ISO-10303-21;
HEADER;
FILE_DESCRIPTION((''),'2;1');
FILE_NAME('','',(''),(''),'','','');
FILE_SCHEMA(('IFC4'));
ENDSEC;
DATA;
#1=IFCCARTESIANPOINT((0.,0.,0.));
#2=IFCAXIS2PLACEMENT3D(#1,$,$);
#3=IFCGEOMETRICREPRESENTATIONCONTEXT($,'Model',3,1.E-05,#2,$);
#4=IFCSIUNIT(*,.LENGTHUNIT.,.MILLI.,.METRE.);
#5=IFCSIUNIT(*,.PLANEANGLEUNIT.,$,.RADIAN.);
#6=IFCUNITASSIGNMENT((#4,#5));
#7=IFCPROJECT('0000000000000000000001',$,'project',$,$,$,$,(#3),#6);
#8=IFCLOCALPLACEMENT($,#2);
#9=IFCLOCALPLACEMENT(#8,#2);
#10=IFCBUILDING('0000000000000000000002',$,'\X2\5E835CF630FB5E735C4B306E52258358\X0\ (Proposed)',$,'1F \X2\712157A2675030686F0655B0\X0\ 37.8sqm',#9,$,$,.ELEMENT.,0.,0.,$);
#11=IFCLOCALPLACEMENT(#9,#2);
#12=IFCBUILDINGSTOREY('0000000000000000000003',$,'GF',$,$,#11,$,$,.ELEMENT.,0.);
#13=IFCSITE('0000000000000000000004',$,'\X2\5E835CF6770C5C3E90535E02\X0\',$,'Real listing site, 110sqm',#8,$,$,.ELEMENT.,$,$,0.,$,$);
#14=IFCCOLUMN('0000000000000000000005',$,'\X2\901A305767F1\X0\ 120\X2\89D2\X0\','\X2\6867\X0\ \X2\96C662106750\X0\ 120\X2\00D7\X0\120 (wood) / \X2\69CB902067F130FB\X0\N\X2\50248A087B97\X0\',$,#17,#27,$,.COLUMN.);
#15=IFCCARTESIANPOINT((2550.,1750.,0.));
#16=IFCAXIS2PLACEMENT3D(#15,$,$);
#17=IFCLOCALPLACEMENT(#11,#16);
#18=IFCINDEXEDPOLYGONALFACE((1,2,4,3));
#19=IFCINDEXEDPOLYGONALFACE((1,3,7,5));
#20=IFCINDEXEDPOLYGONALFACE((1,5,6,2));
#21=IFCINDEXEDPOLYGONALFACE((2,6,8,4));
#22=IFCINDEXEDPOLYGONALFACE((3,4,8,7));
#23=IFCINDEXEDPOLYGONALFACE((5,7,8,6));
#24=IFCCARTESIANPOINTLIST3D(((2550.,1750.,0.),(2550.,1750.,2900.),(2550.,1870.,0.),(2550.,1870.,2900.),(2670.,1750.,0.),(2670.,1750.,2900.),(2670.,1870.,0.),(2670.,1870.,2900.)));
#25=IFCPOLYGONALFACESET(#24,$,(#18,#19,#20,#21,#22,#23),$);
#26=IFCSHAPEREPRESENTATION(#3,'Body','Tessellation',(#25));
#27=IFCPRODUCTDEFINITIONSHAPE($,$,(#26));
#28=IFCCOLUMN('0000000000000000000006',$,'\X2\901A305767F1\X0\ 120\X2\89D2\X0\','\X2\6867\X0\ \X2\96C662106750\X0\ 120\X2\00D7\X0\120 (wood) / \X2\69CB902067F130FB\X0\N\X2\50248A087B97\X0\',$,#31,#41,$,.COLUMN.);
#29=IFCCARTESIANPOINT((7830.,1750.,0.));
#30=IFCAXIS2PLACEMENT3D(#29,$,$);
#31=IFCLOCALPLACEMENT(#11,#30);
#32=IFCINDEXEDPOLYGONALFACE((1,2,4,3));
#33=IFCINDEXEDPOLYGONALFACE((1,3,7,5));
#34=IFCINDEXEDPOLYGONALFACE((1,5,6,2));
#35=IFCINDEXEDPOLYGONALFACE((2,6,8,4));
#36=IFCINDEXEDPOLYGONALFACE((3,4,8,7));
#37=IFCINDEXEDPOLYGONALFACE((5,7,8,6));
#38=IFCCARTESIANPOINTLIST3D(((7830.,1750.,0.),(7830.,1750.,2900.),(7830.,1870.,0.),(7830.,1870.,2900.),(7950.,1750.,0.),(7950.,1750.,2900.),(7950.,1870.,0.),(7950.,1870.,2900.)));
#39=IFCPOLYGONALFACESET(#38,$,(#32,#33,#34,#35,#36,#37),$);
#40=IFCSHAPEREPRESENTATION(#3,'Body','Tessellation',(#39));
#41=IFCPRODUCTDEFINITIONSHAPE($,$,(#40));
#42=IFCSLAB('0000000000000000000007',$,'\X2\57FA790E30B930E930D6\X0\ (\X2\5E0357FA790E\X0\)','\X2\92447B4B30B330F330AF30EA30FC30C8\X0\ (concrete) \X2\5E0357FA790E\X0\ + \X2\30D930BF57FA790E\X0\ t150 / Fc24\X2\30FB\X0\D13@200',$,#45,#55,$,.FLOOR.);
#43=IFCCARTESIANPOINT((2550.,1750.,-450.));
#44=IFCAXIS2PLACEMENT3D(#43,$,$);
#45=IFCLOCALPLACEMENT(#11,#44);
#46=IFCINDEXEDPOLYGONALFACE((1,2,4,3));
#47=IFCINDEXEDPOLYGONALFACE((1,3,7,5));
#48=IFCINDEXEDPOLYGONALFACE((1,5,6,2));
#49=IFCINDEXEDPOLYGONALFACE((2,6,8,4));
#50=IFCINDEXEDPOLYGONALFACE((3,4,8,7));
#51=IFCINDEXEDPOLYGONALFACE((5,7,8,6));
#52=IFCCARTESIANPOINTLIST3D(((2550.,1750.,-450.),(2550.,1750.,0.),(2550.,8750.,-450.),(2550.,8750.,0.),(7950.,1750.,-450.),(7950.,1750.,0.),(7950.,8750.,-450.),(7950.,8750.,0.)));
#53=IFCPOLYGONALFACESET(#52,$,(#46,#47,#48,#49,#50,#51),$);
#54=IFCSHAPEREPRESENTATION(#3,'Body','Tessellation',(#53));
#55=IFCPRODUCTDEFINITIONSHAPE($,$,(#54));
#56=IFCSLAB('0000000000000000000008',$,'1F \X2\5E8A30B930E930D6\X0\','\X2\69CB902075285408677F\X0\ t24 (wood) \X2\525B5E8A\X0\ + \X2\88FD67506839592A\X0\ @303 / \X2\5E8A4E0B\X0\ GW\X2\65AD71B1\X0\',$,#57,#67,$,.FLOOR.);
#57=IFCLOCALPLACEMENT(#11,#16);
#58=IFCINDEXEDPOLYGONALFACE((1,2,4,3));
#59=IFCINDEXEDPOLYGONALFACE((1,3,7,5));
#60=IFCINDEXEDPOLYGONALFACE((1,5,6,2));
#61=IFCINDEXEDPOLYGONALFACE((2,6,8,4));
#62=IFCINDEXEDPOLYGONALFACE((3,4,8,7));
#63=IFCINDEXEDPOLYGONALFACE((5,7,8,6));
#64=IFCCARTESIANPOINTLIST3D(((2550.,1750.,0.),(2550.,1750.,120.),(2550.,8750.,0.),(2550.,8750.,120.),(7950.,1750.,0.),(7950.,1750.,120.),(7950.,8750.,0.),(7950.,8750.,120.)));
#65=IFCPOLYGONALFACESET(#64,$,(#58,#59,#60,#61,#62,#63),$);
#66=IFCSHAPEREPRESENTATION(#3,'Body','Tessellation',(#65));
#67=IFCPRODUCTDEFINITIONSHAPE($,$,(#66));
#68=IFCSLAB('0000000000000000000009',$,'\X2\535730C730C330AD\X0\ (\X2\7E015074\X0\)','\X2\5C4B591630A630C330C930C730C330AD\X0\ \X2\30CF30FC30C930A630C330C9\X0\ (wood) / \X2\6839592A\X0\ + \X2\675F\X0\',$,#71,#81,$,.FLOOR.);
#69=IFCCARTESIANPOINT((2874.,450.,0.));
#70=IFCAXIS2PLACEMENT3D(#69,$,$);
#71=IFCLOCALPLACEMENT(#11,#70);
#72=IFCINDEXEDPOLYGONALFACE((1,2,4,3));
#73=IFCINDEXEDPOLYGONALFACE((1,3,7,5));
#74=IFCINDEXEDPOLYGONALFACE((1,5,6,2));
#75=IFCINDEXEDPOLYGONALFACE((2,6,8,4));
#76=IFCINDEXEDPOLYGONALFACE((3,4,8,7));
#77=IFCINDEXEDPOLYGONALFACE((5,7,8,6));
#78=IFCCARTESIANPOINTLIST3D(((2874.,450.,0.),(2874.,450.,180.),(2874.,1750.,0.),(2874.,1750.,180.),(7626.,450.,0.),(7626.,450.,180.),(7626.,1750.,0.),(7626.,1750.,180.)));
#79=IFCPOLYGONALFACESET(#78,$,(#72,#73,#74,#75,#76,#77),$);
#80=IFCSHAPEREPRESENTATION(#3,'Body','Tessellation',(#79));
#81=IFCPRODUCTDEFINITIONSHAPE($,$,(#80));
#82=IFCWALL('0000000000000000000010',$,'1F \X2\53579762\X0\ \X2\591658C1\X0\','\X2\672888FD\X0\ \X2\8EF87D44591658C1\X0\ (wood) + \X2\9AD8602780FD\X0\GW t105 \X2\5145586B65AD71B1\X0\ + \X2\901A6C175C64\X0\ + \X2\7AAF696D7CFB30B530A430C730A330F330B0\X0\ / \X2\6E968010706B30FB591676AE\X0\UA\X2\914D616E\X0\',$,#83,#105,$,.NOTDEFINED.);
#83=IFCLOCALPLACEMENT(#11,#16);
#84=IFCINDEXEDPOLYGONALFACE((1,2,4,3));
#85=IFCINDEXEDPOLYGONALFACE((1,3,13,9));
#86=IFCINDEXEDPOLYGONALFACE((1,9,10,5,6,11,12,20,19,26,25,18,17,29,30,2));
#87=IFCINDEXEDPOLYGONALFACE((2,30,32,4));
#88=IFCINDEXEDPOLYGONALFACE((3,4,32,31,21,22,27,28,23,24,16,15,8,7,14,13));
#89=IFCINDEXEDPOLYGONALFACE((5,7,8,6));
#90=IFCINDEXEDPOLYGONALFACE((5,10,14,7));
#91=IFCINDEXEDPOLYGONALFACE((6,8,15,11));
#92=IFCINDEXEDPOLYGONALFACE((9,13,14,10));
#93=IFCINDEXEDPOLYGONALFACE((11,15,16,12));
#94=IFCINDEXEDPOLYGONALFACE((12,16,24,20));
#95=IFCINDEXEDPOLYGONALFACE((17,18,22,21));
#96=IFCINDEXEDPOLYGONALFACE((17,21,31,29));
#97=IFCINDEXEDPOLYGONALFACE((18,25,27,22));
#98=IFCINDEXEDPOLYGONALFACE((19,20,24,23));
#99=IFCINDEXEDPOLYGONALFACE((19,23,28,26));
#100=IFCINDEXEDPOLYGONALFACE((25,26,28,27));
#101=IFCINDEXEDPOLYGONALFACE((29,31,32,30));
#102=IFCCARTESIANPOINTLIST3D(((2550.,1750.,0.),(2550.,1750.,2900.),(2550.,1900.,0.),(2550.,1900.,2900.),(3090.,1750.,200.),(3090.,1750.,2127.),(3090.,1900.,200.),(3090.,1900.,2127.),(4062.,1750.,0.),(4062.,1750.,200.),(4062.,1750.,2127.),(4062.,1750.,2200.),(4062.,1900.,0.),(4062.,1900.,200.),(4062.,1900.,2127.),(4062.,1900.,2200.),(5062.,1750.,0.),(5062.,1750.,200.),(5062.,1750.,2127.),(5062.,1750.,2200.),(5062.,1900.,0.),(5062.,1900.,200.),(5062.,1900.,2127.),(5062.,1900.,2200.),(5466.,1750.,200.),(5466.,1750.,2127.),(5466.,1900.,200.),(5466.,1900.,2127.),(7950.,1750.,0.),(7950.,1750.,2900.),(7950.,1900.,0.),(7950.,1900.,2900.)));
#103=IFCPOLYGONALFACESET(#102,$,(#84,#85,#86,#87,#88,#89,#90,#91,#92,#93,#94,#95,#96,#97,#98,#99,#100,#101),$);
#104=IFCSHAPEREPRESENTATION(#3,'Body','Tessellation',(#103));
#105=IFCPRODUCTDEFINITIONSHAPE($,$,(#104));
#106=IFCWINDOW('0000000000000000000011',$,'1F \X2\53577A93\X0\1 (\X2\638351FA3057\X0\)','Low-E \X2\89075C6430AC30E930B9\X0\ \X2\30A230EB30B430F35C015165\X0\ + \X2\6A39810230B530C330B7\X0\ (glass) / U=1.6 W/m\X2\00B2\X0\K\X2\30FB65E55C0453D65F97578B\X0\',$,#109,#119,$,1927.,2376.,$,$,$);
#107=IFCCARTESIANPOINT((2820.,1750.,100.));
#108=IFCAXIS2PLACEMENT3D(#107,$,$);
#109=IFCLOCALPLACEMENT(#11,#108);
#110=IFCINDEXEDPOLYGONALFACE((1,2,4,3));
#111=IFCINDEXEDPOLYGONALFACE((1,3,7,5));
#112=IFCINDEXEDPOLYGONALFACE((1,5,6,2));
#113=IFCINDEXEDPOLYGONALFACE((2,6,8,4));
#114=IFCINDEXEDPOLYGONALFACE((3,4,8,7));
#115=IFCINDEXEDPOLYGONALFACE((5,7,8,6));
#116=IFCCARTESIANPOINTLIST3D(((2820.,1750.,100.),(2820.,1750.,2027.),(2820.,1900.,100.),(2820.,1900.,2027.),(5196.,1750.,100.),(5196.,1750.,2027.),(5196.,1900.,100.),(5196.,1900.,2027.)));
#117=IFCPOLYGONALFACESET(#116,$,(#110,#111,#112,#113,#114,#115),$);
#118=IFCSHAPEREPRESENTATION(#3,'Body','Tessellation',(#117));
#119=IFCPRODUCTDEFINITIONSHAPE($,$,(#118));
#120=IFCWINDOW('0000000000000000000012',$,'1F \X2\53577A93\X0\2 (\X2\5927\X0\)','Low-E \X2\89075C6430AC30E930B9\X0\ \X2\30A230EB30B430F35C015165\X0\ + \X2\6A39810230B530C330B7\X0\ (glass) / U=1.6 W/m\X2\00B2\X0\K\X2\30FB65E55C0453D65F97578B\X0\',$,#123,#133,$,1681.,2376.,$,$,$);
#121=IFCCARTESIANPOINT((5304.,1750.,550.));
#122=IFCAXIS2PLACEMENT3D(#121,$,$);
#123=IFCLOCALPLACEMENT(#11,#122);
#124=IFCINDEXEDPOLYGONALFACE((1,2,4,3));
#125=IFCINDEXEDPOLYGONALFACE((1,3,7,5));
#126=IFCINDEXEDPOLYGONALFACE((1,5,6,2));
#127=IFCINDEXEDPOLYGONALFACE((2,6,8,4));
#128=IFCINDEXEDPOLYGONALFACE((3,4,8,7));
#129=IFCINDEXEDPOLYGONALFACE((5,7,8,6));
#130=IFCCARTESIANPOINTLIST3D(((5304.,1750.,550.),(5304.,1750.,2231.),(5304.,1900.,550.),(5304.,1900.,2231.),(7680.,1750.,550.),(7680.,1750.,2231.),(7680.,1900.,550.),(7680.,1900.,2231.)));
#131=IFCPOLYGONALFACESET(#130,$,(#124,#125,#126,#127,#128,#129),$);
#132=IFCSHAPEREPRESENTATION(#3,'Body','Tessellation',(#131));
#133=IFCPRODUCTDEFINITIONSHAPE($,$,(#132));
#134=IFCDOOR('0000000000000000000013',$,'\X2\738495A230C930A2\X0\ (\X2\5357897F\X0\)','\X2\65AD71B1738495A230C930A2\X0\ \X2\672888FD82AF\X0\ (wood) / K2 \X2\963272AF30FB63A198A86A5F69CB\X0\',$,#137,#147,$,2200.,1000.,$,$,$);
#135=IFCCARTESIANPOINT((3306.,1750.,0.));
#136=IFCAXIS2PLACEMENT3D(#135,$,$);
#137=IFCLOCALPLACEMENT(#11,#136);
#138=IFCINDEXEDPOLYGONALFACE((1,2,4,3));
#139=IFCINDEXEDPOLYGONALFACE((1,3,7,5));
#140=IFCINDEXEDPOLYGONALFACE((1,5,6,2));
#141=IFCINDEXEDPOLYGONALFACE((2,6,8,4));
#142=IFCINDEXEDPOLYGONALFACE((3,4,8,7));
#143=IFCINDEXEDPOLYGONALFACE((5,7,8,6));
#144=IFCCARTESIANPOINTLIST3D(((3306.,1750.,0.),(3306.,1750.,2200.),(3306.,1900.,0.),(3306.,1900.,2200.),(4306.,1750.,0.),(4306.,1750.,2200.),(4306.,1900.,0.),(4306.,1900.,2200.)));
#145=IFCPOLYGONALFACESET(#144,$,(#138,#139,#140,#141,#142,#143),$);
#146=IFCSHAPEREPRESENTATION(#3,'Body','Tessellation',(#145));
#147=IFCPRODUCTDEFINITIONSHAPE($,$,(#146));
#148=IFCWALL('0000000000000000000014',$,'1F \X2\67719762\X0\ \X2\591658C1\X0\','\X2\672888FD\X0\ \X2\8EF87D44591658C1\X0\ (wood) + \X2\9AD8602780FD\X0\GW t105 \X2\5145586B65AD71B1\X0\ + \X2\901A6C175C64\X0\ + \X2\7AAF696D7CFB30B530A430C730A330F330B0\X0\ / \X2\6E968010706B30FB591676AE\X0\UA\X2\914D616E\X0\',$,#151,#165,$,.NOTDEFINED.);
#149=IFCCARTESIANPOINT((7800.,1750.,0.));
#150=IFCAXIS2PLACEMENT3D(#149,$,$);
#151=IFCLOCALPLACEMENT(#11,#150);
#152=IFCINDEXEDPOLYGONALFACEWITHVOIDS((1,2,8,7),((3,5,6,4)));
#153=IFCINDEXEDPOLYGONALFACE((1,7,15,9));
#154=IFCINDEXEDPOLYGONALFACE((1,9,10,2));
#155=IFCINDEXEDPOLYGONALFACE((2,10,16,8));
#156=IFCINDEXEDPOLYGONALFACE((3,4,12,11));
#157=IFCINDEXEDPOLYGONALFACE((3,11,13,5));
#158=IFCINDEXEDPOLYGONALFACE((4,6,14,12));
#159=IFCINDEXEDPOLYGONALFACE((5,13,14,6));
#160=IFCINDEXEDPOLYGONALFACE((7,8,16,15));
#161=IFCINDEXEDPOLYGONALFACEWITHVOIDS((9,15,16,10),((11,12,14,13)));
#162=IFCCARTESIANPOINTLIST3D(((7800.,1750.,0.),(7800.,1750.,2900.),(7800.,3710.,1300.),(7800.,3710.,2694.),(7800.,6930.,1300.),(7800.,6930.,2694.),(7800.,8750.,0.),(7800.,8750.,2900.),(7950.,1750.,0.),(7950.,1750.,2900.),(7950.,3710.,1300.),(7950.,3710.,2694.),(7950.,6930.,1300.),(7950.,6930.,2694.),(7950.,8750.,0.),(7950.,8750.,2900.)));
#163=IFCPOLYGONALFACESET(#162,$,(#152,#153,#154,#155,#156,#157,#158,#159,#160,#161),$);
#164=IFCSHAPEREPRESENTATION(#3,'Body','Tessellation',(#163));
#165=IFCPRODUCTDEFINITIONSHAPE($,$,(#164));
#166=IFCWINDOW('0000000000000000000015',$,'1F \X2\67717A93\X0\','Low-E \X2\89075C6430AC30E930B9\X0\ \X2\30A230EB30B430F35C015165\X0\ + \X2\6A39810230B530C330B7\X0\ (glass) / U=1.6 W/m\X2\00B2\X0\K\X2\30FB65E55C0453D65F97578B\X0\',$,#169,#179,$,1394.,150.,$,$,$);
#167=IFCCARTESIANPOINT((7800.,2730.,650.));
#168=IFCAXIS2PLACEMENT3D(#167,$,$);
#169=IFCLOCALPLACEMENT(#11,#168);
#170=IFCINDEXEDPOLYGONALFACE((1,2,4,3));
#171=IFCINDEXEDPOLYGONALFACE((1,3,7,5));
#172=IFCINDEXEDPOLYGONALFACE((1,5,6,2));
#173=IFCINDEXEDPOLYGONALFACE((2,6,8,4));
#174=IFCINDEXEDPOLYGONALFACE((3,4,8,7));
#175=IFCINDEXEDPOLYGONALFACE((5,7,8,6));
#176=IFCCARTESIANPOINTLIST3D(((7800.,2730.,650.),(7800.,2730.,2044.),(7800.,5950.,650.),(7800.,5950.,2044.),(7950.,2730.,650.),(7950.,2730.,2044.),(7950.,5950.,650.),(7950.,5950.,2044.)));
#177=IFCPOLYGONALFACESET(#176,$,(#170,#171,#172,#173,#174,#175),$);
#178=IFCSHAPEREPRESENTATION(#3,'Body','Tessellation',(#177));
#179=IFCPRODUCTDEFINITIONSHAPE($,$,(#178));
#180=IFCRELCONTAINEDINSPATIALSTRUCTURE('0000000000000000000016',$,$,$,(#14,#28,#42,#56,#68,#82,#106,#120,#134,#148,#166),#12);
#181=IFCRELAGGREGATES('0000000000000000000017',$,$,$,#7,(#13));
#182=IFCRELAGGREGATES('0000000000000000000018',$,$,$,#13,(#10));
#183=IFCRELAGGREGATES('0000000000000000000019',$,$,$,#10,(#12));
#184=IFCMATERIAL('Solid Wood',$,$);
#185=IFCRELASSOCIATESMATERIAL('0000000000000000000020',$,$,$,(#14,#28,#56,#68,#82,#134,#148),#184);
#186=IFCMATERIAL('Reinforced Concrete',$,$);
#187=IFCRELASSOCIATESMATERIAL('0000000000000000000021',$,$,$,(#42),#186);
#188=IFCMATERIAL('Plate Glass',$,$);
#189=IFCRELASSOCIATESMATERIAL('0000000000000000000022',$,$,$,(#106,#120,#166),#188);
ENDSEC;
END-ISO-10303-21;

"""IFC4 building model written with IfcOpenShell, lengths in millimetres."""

from ifc_helpers import new_model, si_unit, frame, frame_2d, origin, place, context, project, spatial, rectangle, extrude, material, element, fill, save


model = new_model("IFC4")

# Units and contexts
model_context = context("Model", 3, precision=1e-05, world=origin())
ifc_project = project(units=[si_unit("LENGTHUNIT", "METRE", prefix="MILLI"), si_unit("PLANEANGLEUNIT", "RADIAN")], contexts=[model_context])

# Site, building, storey
site_placement = place(None, origin())
site = spatial("IfcSite", under=ifc_project, at=site_placement, Name="広島県尾道市", ObjectType="Real listing site, 110sqm", CompositionType="ELEMENT", RefElevation=0.0)
building_placement = place(site_placement, origin())
building = spatial("IfcBuilding", under=site, at=building_placement, Name="広島・平屋の別荘 (Proposed)", ObjectType="1F 無垢材と漆喰 37.8sqm", CompositionType="ELEMENT", ElevationOfRefHeight=0.0, ElevationOfTerrain=0.0)
storey_placement = place(building_placement, origin())
storey = spatial("IfcBuildingStorey", under=building, at=storey_placement, Name="GF", CompositionType="ELEMENT", Elevation=0.0)

# Columns
ifc_material_1 = material(Name="Solid Wood")
column_1_placement = place(storey_placement, frame((2550.0, 1750.0, 0.0)))
element("IfcColumn", 1, at=column_1_placement, inside=storey, material=ifc_material_1, Name="通し柱 120角", Description="桧 集成材 120×120 (wood) / 構造柱・N値計算", PredefinedType="COLUMN", context=model_context, shape_type="SweptSolid", body=[
    extrude(rectangle(XDim=120.0, YDim=120.0, at=frame_2d((60.0, 60.0))), frame((2550.0, 1750.0, 0.0)), (0.0, 0.0, 1.0), 2900.0),
])
column_2_placement = place(storey_placement, frame((7830.0, 1750.0, 0.0)))
element("IfcColumn", 2, at=column_2_placement, inside=storey, material=ifc_material_1, Name="通し柱 120角", Description="桧 集成材 120×120 (wood) / 構造柱・N値計算", PredefinedType="COLUMN", context=model_context, shape_type="SweptSolid", body=[
    extrude(rectangle(XDim=120.0, YDim=120.0, at=frame_2d((60.0, 60.0))), frame((7830.0, 1750.0, 0.0)), (0.0, 0.0, 1.0), 2900.0),
])

# Slabs
ifc_material_2 = material(Name="Reinforced Concrete")
slab_1_placement = place(storey_placement, frame((2550.0, 1750.0, -450.0)))
element("IfcSlab", 3, at=slab_1_placement, inside=storey, material=ifc_material_2, Name="基礎スラブ (布基礎)", Description="鉄筋コンクリート (concrete) 布基礎 + ベタ基礎 t150 / Fc24・D13@200", PredefinedType="FLOOR", context=model_context, shape_type="SweptSolid", body=[
    extrude(rectangle(XDim=5400.0, YDim=7000.0, at=frame_2d((2700.0, 3500.0))), frame((2550.0, 1750.0, -450.0)), (0.0, 0.0, 1.0), 450.0),
])
slab_2_placement = place(storey_placement, frame((2550.0, 1750.0, 0.0)))
element("IfcSlab", 4, at=slab_2_placement, inside=storey, material=ifc_material_1, Name="1F 床スラブ", Description="構造用合板 t24 (wood) 剛床 + 製材根太 @303 / 床下 GW断熱", PredefinedType="FLOOR", context=model_context, shape_type="SweptSolid", body=[
    extrude(rectangle(XDim=5400.0, YDim=7000.0, at=frame_2d((2700.0, 3500.0))), frame((2550.0, 1750.0, 0.0)), (0.0, 0.0, 1.0), 120.0),
])
slab_3_placement = place(storey_placement, frame((2874.0, 450.0, 0.0)))
element("IfcSlab", 5, at=slab_3_placement, inside=storey, material=ifc_material_1, Name="南デッキ (縁側)", Description="屋外ウッドデッキ ハードウッド (wood) / 根太 + 束", PredefinedType="FLOOR", context=model_context, shape_type="SweptSolid", body=[
    extrude(rectangle(XDim=4752.0, YDim=1300.0, at=frame_2d((2376.0, 650.0))), frame((2874.0, 450.0, 0.0)), (0.0, 0.0, 1.0), 180.0),
])

# Wall, openings, windows, door
wall_1_placement = place(storey_placement, frame((2550.0, 1750.0, 0.0)))
wall_1 = element("IfcWall", 6, at=wall_1_placement, inside=storey, material=ifc_material_1, Name="1F 南面 外壁", Description="木製 軸組外壁 (wood) + 高性能GW t105 充填断熱 + 通気層 + 窯業系サイディング / 準耐火・外皮UA配慮", PredefinedType="NOTDEFINED", context=model_context, shape_type="SweptSolid", body=[
    extrude(rectangle(XDim=5400.0, YDim=150.0, at=frame_2d((2700.0, 75.0))), frame((2550.0, 1750.0, 0.0)), (0.0, 0.0, 1.0), 2900.0),
])
opening_1_placement = place(storey_placement, frame((2820.0, 1750.0, 100.0)))
opening_1 = element("IfcOpeningElement", 7, at=opening_1_placement, cuts=wall_1, PredefinedType="NOTDEFINED", context=model_context, shape_type="SweptSolid", body=[
    extrude(rectangle(XDim=2376.0, YDim=150.0, at=frame_2d((1188.0, 75.0))), frame((2820.0, 1750.0, 100.0)), (0.0, 0.0, 1.0), 1927.0),
])
opening_2_placement = place(storey_placement, frame((5304.0, 1750.0, 550.0)))
opening_2 = element("IfcOpeningElement", 8, at=opening_2_placement, cuts=wall_1, PredefinedType="NOTDEFINED", context=model_context, shape_type="SweptSolid", body=[
    extrude(rectangle(XDim=2376.0, YDim=150.0, at=frame_2d((1188.0, 75.0))), frame((5304.0, 1750.0, 550.0)), (0.0, 0.0, 1.0), 1681.0),
])
opening_3_placement = place(storey_placement, frame((3306.0, 1750.0, 0.0)))
opening_3 = element("IfcOpeningElement", 9, at=opening_3_placement, cuts=wall_1, PredefinedType="NOTDEFINED", context=model_context, shape_type="SweptSolid", body=[
    extrude(rectangle(XDim=1000.0, YDim=150.0, at=frame_2d((500.0, 75.0))), frame((3306.0, 1750.0, 0.0)), (0.0, 0.0, 1.0), 2200.0),
])
ifc_material_3 = material(Name="Plate Glass")
window_1_placement = place(storey_placement, frame((2820.0, 1750.0, 100.0)))
window_1 = element("IfcWindow", 10, at=window_1_placement, inside=storey, material=ifc_material_3, Name="1F 南窓1 (掃出し)", Description="Low-E 複層ガラス アルゴン封入 + 樹脂サッシ (glass) / U=1.6 W/m²K・日射取得型", OverallHeight=1927.0, OverallWidth=2376.0, context=model_context, shape_type="SweptSolid", body=[
    extrude(rectangle(XDim=2376.0, YDim=150.0, at=frame_2d((1188.0, 75.0))), frame((2820.0, 1750.0, 100.0)), (0.0, 0.0, 1.0), 1927.0),
])
fill(opening_1, window_1)
window_2_placement = place(storey_placement, frame((5304.0, 1750.0, 550.0)))
window_2 = element("IfcWindow", 11, at=window_2_placement, inside=storey, material=ifc_material_3, Name="1F 南窓2 (大)", Description="Low-E 複層ガラス アルゴン封入 + 樹脂サッシ (glass) / U=1.6 W/m²K・日射取得型", OverallHeight=1681.0, OverallWidth=2376.0, context=model_context, shape_type="SweptSolid", body=[
    extrude(rectangle(XDim=2376.0, YDim=150.0, at=frame_2d((1188.0, 75.0))), frame((5304.0, 1750.0, 550.0)), (0.0, 0.0, 1.0), 1681.0),
])
fill(opening_2, window_2)
door_placement = place(storey_placement, frame((3306.0, 1750.0, 0.0)))
door = element("IfcDoor", 12, at=door_placement, inside=storey, material=ifc_material_1, Name="玄関ドア (南西)", Description="断熱玄関ドア 木製芯 (wood) / K2 防犯・採風機構", OverallHeight=2200.0, OverallWidth=1000.0, context=model_context, shape_type="SweptSolid", body=[
    extrude(rectangle(XDim=1000.0, YDim=150.0, at=frame_2d((500.0, 75.0))), frame((3306.0, 1750.0, 0.0)), (0.0, 0.0, 1.0), 2200.0),
])
fill(opening_3, door)

# Wall, opening, window
wall_2_placement = place(storey_placement, frame((7800.0, 1750.0, 0.0)))
wall_2 = element("IfcWall", 13, at=wall_2_placement, inside=storey, material=ifc_material_1, Name="1F 東面 外壁", Description="木製 軸組外壁 (wood) + 高性能GW t105 充填断熱 + 通気層 + 窯業系サイディング / 準耐火・外皮UA配慮", PredefinedType="NOTDEFINED", context=model_context, shape_type="SweptSolid", body=[
    extrude(rectangle(XDim=150.0, YDim=7000.0, at=frame_2d((75.0, 3500.0))), frame((7800.0, 1750.0, 0.0)), (0.0, 0.0, 1.0), 2900.0),
])
opening_4_placement = place(storey_placement, frame((7800.0, 2730.0, 650.0)))
opening_4 = element("IfcOpeningElement", 14, at=opening_4_placement, cuts=wall_2, PredefinedType="NOTDEFINED", context=model_context, shape_type="SweptSolid", body=[
    extrude(rectangle(XDim=150.0, YDim=3220.0, at=frame_2d((75.0, 1610.0))), frame((7800.0, 2730.0, 650.0)), (0.0, 0.0, 1.0), 1394.0),
])
window_3_placement = place(storey_placement, frame((7800.0, 2730.0, 650.0)))
window_3 = element("IfcWindow", 15, at=window_3_placement, inside=storey, material=ifc_material_3, Name="1F 東窓", Description="Low-E 複層ガラス アルゴン封入 + 樹脂サッシ (glass) / U=1.6 W/m²K・日射取得型", OverallHeight=1394.0, OverallWidth=150.0, context=model_context, shape_type="SweptSolid", body=[
    extrude(rectangle(XDim=150.0, YDim=3220.0, at=frame_2d((75.0, 1610.0))), frame((7800.0, 2730.0, 650.0)), (0.0, 0.0, 1.0), 1394.0),
])
fill(opening_4, window_3)

save(model, "model.ifc")
